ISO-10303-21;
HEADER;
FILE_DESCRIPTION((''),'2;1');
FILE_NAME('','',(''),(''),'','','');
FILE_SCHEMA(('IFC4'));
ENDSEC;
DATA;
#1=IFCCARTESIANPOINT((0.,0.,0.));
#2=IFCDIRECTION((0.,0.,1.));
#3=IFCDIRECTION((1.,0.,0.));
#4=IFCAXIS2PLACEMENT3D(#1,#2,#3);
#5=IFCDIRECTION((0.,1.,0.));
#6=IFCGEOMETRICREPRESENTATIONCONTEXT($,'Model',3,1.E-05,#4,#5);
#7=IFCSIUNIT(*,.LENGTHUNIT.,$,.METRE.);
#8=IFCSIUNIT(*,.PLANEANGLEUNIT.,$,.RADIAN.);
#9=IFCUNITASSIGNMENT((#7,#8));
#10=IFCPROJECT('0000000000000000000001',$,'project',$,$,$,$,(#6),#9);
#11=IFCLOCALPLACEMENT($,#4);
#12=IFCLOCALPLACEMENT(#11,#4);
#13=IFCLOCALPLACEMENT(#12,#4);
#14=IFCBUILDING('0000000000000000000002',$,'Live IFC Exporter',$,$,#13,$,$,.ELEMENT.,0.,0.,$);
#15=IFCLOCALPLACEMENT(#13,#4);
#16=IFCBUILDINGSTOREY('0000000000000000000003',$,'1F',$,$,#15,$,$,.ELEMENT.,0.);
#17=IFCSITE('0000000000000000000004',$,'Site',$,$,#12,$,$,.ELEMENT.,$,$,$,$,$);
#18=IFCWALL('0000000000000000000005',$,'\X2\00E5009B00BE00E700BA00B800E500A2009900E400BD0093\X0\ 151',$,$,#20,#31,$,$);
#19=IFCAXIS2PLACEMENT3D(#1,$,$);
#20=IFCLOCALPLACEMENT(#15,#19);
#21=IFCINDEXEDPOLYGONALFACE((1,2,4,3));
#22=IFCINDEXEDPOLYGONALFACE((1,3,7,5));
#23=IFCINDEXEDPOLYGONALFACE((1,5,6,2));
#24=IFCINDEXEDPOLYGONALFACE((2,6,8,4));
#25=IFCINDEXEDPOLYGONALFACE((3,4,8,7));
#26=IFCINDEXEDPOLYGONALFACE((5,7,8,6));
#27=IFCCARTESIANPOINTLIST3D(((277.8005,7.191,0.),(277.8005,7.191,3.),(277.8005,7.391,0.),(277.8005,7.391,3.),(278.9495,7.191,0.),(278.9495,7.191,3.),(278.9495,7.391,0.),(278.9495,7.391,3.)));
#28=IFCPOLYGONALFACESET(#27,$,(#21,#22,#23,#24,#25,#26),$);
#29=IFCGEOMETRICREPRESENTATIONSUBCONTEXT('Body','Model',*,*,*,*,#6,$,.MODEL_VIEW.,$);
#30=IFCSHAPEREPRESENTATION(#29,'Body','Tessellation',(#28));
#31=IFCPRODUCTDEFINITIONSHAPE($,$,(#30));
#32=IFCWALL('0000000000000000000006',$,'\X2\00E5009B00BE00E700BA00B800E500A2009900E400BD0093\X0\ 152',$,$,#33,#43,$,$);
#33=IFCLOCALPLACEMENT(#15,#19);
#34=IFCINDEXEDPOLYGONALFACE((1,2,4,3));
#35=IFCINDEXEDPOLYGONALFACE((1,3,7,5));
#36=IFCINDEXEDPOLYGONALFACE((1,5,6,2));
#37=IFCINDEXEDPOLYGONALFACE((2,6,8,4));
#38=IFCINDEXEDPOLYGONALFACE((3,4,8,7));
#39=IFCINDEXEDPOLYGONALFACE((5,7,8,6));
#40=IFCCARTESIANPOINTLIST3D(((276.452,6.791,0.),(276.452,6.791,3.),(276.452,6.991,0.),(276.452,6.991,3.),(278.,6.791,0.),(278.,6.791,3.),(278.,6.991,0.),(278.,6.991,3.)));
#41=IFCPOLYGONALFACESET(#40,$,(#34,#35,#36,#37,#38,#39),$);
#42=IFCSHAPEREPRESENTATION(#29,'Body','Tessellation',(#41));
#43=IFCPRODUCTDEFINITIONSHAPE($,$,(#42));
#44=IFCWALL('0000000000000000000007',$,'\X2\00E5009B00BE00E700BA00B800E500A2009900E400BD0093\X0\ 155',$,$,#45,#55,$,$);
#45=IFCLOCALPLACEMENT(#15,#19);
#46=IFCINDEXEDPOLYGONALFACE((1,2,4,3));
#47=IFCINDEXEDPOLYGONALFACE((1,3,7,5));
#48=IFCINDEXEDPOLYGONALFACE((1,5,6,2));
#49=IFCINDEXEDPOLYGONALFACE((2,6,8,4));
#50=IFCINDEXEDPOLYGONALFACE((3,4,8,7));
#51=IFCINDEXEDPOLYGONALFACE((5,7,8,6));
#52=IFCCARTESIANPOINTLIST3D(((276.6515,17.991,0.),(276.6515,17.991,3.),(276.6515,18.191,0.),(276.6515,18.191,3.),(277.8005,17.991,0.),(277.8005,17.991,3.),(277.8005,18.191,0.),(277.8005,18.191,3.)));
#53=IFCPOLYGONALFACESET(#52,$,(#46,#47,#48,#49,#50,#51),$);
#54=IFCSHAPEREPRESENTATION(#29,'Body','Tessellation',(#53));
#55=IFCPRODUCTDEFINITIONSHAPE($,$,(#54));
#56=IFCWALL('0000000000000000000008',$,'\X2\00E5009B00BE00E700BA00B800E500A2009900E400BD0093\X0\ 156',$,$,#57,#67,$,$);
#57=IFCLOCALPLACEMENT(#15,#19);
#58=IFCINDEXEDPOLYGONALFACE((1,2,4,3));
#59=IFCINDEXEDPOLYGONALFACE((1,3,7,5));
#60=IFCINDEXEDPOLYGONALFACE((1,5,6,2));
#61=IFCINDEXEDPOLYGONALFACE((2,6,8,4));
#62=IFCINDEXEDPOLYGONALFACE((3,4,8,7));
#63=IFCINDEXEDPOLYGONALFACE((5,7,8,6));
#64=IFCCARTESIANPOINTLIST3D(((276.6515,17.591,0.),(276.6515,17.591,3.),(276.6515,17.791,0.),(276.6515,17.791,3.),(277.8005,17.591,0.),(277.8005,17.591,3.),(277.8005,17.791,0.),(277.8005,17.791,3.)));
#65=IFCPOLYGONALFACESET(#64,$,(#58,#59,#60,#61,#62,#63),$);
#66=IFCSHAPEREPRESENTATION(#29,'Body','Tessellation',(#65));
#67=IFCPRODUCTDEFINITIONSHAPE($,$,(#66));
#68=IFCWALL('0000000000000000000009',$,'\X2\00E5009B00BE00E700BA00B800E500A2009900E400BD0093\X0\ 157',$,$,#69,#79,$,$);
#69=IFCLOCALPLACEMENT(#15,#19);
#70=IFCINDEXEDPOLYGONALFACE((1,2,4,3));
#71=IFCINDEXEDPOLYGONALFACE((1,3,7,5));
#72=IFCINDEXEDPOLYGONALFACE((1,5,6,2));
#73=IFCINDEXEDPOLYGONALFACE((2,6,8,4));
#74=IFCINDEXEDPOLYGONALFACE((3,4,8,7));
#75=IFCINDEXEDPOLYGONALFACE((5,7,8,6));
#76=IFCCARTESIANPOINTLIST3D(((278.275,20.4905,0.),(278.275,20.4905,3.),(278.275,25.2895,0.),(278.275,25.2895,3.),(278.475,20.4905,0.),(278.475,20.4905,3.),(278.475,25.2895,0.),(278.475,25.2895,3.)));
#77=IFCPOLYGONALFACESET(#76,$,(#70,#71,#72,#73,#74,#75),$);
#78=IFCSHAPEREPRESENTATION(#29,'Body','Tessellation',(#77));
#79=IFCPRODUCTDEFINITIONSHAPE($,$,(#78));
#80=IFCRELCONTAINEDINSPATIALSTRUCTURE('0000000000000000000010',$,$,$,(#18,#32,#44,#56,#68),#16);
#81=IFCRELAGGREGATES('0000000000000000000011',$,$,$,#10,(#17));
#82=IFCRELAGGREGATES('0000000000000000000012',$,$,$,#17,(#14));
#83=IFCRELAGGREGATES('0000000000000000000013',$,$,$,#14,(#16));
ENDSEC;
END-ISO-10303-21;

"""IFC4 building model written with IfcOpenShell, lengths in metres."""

from ifc_helpers import new_model, si_unit, direction, frame, frame_2d, origin_with_axes, place, context, subcontext, project, spatial, rectangle, extrude, element, save


model = new_model("IFC4")

# Units and contexts
model_context = context("Model", 3, precision=1e-05, world=origin_with_axes(), true_north=direction((0.0, 1.0, 0.0)))
body_context = subcontext(model_context, "Body", "Model", "MODEL_VIEW")
ifc_project = project(units=[si_unit("LENGTHUNIT", "METRE"), si_unit("PLANEANGLEUNIT", "RADIAN")], contexts=[model_context])

# Site, building, storey
placement = place(None, origin_with_axes())
site_placement = place(placement, origin_with_axes())
site = spatial("IfcSite", under=ifc_project, at=site_placement, Name="Site", CompositionType="ELEMENT")
building_placement = place(site_placement, origin_with_axes())
building = spatial("IfcBuilding", under=site, at=building_placement, Name="Live IFC Exporter", CompositionType="ELEMENT", ElevationOfRefHeight=0.0, ElevationOfTerrain=0.0)
storey_placement = place(building_placement, origin_with_axes())
storey = spatial("IfcBuildingStorey", under=building, at=storey_placement, Name="1F", CompositionType="ELEMENT", Elevation=0.0)

# Walls
wall_1_placement = place(storey_placement, frame((278.375, 7.291, 0.0), z_axis=(0.0, 0.0, 1.0), x_axis=(-1.0, 0.0, 0.0)))
element("IfcWall", 1, at=wall_1_placement, inside=storey, Name="å\u009b¾çº¸å¢\u0099ä½\u0093 151", context=body_context, shape_type="SweptSolid", body=[
    extrude(rectangle(XDim=1.149, YDim=0.2, at=frame_2d((0.0, 0.0), x_axis=(1.0, 0.0, 0.0))), frame((0.0, 0.0, 0.0), z_axis=(0.0, 0.0, 1.0)), (0.0, 0.0, 1.0), 3.0),
])
wall_2_placement = place(storey_placement, frame((277.226, 6.891, 0.0), z_axis=(0.0, 0.0, 1.0), x_axis=(1.0, 0.0, 0.0)))
element("IfcWall", 2, at=wall_2_placement, inside=storey, Name="å\u009b¾çº¸å¢\u0099ä½\u0093 152", context=body_context, shape_type="SweptSolid", body=[
    extrude(rectangle(XDim=1.548, YDim=0.2, at=frame_2d((0.0, 0.0), x_axis=(1.0, 0.0, 0.0))), frame((0.0, 0.0, 0.0), z_axis=(0.0, 0.0, 1.0)), (0.0, 0.0, 1.0), 3.0),
])
for number, where, z_axis, x_axis, name in (
    (3, (277.226, 18.091, 0.0), (0.0, 0.0, 1.0), (1.0, 0.0, 0.0), "å\u009b¾çº¸å¢\u0099ä½\u0093 155"),
    (4, (277.226, 17.691, 0.0), (0.0, 0.0, 1.0), (1.0, 0.0, 0.0), "å\u009b¾çº¸å¢\u0099ä½\u0093 156"),
):
    element("IfcWall", number, at=place(storey_placement, frame(where, z_axis=z_axis, x_axis=x_axis)), inside=storey, Name=name, context=body_context, shape_type="SweptSolid", body=[
        extrude(rectangle(XDim=1.149, YDim=0.2, at=frame_2d((0.0, 0.0), x_axis=(1.0, 0.0, 0.0))), frame((0.0, 0.0, 0.0), z_axis=(0.0, 0.0, 1.0)), (0.0, 0.0, 1.0), 3.0),
    ])
wall_3_placement = place(storey_placement, frame((278.375, 22.89, 0.0), z_axis=(0.0, 0.0, 1.0), x_axis=(0.0, -1.0, 0.0)))
element("IfcWall", 5, at=wall_3_placement, inside=storey, Name="å\u009b¾çº¸å¢\u0099ä½\u0093 157", context=body_context, shape_type="SweptSolid", body=[
    extrude(rectangle(XDim=4.799, YDim=0.2, at=frame_2d((0.0, 0.0), x_axis=(1.0, 0.0, 0.0))), frame((0.0, 0.0, 0.0), z_axis=(0.0, 0.0, 1.0)), (0.0, 0.0, 1.0), 3.0),
])

save(model, "model.ifc")
